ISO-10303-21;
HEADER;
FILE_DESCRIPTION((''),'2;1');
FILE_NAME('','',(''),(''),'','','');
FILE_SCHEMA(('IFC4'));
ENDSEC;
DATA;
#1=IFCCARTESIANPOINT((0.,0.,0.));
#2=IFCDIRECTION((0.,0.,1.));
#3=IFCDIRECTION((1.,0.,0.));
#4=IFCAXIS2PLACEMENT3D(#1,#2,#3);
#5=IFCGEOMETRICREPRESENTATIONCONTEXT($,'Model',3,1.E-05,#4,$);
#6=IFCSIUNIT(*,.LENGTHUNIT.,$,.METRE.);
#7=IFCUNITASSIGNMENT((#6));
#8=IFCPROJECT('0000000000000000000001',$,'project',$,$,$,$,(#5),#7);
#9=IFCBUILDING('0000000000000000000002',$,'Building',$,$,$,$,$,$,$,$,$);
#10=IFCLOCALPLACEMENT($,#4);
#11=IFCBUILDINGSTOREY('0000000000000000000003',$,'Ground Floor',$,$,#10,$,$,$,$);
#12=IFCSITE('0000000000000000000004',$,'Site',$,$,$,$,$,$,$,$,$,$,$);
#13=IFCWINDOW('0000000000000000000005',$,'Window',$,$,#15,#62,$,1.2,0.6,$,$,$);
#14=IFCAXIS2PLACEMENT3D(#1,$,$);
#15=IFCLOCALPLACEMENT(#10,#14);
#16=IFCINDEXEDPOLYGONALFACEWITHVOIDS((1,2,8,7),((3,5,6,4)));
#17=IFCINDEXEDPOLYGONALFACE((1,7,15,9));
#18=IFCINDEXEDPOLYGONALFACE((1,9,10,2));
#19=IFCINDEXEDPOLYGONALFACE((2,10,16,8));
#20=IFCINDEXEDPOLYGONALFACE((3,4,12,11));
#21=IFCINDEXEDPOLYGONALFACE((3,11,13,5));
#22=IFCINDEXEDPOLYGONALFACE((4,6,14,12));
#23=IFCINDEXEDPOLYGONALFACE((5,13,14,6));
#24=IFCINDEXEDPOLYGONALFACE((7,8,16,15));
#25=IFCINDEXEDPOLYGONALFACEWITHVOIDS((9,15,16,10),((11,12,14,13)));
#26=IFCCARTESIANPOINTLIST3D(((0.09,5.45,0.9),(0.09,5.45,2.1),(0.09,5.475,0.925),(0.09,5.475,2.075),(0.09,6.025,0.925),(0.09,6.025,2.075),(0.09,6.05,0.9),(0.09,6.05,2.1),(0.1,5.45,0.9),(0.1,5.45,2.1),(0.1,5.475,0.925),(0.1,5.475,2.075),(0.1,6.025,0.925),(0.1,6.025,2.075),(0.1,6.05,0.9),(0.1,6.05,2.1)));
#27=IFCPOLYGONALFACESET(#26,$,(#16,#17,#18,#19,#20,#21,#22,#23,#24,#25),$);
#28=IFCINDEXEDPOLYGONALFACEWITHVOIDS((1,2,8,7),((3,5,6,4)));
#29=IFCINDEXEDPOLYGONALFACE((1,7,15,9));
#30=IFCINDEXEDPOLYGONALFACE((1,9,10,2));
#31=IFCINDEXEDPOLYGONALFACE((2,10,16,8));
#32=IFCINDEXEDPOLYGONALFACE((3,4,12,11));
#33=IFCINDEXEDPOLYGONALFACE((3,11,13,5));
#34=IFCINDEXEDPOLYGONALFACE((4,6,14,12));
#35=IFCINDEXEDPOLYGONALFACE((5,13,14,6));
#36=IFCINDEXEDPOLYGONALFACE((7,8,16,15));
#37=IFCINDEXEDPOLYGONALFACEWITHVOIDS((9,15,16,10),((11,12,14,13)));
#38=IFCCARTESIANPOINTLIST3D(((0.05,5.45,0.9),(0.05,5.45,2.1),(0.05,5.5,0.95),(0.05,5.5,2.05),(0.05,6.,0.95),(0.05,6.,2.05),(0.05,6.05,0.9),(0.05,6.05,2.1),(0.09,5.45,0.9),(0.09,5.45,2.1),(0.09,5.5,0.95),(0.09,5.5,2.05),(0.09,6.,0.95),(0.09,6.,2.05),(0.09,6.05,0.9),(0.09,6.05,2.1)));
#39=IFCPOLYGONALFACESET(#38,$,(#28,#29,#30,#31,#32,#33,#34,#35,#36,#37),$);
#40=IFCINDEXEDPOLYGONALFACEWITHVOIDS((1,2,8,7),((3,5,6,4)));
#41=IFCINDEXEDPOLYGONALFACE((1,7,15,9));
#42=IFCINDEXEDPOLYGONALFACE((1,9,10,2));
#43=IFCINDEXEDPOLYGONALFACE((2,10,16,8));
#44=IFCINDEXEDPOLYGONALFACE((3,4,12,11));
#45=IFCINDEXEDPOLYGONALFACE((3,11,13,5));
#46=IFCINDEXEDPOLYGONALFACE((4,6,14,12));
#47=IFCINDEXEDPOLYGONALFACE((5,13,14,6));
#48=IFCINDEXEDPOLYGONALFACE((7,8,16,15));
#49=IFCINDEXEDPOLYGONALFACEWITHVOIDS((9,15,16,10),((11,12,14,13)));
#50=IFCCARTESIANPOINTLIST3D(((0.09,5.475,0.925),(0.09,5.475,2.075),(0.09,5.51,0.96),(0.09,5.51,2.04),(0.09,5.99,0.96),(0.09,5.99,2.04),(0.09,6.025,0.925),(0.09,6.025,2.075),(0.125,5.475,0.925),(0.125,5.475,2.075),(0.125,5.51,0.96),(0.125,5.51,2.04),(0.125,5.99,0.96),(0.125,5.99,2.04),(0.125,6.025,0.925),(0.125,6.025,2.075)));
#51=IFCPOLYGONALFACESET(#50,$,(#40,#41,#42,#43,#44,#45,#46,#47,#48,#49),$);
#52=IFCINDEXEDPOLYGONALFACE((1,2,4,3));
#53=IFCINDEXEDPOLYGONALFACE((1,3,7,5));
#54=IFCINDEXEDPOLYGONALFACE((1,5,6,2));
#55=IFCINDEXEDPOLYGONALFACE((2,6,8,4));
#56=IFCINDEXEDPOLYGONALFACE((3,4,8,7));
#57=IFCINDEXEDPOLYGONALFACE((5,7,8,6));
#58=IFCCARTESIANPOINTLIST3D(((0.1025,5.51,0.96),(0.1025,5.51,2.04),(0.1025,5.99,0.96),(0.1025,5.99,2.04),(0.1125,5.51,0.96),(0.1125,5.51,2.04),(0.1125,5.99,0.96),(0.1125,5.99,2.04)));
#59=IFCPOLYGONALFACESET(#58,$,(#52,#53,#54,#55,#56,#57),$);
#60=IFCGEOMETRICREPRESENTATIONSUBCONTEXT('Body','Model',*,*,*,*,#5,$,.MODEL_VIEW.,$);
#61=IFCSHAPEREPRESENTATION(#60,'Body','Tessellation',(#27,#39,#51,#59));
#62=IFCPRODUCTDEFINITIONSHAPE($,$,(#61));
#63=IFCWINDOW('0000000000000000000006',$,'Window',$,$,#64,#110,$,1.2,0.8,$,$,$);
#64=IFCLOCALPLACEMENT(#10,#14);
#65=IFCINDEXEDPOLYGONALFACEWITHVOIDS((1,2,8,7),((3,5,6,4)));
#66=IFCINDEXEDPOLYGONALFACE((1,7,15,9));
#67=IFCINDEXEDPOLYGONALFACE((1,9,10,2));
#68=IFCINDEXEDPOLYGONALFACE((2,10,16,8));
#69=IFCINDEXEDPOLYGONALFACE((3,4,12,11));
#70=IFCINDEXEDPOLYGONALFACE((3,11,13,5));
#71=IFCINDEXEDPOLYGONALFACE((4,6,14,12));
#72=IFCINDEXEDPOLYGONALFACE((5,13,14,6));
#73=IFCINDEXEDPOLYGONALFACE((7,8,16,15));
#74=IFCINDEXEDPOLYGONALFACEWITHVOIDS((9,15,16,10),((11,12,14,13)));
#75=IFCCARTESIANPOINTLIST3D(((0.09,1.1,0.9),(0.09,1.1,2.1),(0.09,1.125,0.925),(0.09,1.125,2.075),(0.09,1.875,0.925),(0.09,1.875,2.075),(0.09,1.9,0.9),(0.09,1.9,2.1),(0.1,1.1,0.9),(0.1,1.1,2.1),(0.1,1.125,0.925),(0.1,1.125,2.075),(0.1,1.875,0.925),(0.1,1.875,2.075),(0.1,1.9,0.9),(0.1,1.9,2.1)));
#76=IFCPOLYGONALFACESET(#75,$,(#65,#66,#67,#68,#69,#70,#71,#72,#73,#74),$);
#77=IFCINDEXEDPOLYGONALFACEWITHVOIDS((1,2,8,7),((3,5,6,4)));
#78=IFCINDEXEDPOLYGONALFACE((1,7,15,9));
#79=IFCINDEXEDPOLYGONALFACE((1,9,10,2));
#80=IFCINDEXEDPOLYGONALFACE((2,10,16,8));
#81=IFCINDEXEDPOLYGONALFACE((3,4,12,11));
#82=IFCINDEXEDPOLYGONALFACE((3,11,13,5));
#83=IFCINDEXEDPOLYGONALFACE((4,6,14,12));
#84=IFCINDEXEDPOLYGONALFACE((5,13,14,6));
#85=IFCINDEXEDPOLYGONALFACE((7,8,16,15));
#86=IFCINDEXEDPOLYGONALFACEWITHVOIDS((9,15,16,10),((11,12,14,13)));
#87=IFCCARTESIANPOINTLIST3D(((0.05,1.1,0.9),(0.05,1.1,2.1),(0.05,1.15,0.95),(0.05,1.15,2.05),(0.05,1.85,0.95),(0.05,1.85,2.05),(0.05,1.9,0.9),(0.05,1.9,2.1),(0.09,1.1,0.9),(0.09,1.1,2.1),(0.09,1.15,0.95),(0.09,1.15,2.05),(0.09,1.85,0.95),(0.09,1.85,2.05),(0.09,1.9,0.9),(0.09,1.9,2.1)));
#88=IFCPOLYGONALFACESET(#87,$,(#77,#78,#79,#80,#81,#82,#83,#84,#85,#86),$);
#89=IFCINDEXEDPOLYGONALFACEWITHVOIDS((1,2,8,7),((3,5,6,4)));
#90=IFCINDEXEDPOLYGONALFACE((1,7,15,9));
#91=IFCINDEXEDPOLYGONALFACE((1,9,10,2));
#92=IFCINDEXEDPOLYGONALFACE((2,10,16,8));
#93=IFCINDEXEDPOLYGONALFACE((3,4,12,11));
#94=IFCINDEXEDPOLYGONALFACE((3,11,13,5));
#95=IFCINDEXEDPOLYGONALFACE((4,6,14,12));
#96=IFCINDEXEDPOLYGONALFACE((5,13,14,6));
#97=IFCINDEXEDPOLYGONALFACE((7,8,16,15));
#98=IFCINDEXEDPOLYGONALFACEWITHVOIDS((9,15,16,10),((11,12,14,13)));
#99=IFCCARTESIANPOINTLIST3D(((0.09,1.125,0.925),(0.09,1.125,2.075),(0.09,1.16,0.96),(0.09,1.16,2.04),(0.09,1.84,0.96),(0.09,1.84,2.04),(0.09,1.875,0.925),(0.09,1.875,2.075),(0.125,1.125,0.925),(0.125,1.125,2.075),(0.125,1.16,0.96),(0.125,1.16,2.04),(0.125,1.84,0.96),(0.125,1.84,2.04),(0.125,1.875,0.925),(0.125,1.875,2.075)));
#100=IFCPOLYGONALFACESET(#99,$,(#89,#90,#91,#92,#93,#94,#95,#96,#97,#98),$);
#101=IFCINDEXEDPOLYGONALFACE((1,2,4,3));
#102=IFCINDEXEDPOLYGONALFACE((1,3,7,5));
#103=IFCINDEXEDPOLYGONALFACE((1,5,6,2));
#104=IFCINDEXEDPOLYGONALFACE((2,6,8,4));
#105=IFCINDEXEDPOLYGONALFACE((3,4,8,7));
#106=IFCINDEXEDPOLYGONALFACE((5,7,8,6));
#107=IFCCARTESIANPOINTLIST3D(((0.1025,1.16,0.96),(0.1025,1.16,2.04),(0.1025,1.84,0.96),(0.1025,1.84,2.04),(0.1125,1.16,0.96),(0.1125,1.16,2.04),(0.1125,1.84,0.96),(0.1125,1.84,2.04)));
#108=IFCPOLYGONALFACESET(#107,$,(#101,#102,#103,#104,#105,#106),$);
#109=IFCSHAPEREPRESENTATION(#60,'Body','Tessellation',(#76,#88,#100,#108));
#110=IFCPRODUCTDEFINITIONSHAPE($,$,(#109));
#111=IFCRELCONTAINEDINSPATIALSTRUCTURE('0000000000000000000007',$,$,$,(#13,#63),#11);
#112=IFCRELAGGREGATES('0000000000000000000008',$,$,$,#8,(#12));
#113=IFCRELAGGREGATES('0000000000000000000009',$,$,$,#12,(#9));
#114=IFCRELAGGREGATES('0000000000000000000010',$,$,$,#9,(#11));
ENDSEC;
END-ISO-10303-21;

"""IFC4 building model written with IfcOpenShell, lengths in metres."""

from ifc_helpers import new_model, si_unit, frame, origin_with_axes, place, context, subcontext, project, spatial, line, indexed_curve, outline, extrude, element, save


model = new_model("IFC4")

# Units and contexts
model_context = context("Model", 3, precision=1e-05, world=origin_with_axes())
body_context = subcontext(model_context, "Body", "Model", "MODEL_VIEW")
ifc_project = project(units=[si_unit("LENGTHUNIT", "METRE")], contexts=[model_context])

# Site, building, storey
site = spatial("IfcSite", under=ifc_project, Name="Site")
building = spatial("IfcBuilding", under=site, Name="Building")
storey_placement = place(None, origin_with_axes())
storey = spatial("IfcBuildingStorey", under=building, at=storey_placement, Name="Ground Floor")

# Windows
window_1_placement = place(storey_placement, frame((0.0, 6.05, 0.9), z_axis=(0.0, 0.0, 1.0), x_axis=(0.0, -1.0, 0.0)))
element("IfcWindow", 1, at=window_1_placement, inside=storey, Name="Window", OverallHeight=1.2, OverallWidth=0.6, context=body_context, shape_type="SweptSolid", body=[
    extrude(outline(indexed_curve([(0.0, 0.0), (0.6, 0.0), (0.6, 1.2), (0.0, 1.2)], segments=[line(1, 2, 3, 4, 1)]), holes=[indexed_curve([(0.025, 0.025), (0.575, 0.025), (0.575, 1.175), (0.025, 1.175)], segments=[line(1, 2, 3, 4, 1)])]), frame((0.0, 0.09, 0.0), z_axis=(0.0, -1.0, 0.0), x_axis=(1.0, 0.0, 0.0)), (0.0, 0.0, -1.0), 0.01),
    extrude(outline(indexed_curve([(0.0, 0.0), (0.6, 0.0), (0.6, 1.2), (0.0, 1.2)], segments=[line(1, 2, 3, 4, 1)]), holes=[indexed_curve([(0.05, 0.05), (0.55, 0.05), (0.55, 1.15), (0.05, 1.15)], segments=[line(1, 2, 3, 4, 1)])]), frame((0.0, 0.05, 0.0), z_axis=(0.0, -1.0, 0.0), x_axis=(1.0, 0.0, 0.0)), (0.0, 0.0, -1.0), 0.04),
    extrude(outline(indexed_curve([(0.0, 0.0), (0.55, 0.0), (0.55, 1.15), (0.0, 1.15)], segments=[line(1, 2, 3, 4, 1)]), holes=[indexed_curve([(0.035, 0.035), (0.515, 0.035), (0.515, 1.115), (0.035, 1.115)], segments=[line(1, 2, 3, 4, 1)])]), frame((0.025, 0.09, 0.025), z_axis=(0.0, -1.0, 0.0), x_axis=(1.0, 0.0, 0.0)), (0.0, 0.0, -1.0), 0.035),
    extrude(outline(indexed_curve([(0.035, 0.035), (0.515, 0.035), (0.515, 1.115), (0.035, 1.115)], segments=[line(1, 2, 3, 4, 1)])), frame((0.025, 0.1025, 0.025), z_axis=(0.0, -1.0, 0.0), x_axis=(1.0, 0.0, 0.0)), (0.0, 0.0, -1.0), 0.01),
])
window_2_placement = place(storey_placement, frame((0.0, 1.9, 0.9), z_axis=(0.0, 0.0, 1.0), x_axis=(0.0, -1.0, 0.0)))
element("IfcWindow", 2, at=window_2_placement, inside=storey, Name="Window", OverallHeight=1.2, OverallWidth=0.8, context=body_context, shape_type="SweptSolid", body=[
    extrude(outline(indexed_curve([(0.0, 0.0), (0.8, 0.0), (0.8, 1.2), (0.0, 1.2)], segments=[line(1, 2, 3, 4, 1)]), holes=[indexed_curve([(0.025, 0.025), (0.775, 0.025), (0.775, 1.175), (0.025, 1.175)], segments=[line(1, 2, 3, 4, 1)])]), frame((0.0, 0.09, 0.0), z_axis=(0.0, -1.0, 0.0), x_axis=(1.0, 0.0, 0.0)), (0.0, 0.0, -1.0), 0.01),
    extrude(outline(indexed_curve([(0.0, 0.0), (0.8, 0.0), (0.8, 1.2), (0.0, 1.2)], segments=[line(1, 2, 3, 4, 1)]), holes=[indexed_curve([(0.05, 0.05), (0.75, 0.05), (0.75, 1.15), (0.05, 1.15)], segments=[line(1, 2, 3, 4, 1)])]), frame((0.0, 0.05, 0.0), z_axis=(0.0, -1.0, 0.0), x_axis=(1.0, 0.0, 0.0)), (0.0, 0.0, -1.0), 0.04),
    extrude(outline(indexed_curve([(0.0, 0.0), (0.75, 0.0), (0.75, 1.15), (0.0, 1.15)], segments=[line(1, 2, 3, 4, 1)]), holes=[indexed_curve([(0.035, 0.035), (0.715, 0.035), (0.715, 1.115), (0.035, 1.115)], segments=[line(1, 2, 3, 4, 1)])]), frame((0.025, 0.09, 0.025), z_axis=(0.0, -1.0, 0.0), x_axis=(1.0, 0.0, 0.0)), (0.0, 0.0, -1.0), 0.035),
    extrude(outline(indexed_curve([(0.035, 0.035), (0.715, 0.035), (0.715, 1.115), (0.035, 1.115)], segments=[line(1, 2, 3, 4, 1)])), frame((0.025, 0.1025, 0.025), z_axis=(0.0, -1.0, 0.0), x_axis=(1.0, 0.0, 0.0)), (0.0, 0.0, -1.0), 0.01),
])

save(model, "model.ifc")
